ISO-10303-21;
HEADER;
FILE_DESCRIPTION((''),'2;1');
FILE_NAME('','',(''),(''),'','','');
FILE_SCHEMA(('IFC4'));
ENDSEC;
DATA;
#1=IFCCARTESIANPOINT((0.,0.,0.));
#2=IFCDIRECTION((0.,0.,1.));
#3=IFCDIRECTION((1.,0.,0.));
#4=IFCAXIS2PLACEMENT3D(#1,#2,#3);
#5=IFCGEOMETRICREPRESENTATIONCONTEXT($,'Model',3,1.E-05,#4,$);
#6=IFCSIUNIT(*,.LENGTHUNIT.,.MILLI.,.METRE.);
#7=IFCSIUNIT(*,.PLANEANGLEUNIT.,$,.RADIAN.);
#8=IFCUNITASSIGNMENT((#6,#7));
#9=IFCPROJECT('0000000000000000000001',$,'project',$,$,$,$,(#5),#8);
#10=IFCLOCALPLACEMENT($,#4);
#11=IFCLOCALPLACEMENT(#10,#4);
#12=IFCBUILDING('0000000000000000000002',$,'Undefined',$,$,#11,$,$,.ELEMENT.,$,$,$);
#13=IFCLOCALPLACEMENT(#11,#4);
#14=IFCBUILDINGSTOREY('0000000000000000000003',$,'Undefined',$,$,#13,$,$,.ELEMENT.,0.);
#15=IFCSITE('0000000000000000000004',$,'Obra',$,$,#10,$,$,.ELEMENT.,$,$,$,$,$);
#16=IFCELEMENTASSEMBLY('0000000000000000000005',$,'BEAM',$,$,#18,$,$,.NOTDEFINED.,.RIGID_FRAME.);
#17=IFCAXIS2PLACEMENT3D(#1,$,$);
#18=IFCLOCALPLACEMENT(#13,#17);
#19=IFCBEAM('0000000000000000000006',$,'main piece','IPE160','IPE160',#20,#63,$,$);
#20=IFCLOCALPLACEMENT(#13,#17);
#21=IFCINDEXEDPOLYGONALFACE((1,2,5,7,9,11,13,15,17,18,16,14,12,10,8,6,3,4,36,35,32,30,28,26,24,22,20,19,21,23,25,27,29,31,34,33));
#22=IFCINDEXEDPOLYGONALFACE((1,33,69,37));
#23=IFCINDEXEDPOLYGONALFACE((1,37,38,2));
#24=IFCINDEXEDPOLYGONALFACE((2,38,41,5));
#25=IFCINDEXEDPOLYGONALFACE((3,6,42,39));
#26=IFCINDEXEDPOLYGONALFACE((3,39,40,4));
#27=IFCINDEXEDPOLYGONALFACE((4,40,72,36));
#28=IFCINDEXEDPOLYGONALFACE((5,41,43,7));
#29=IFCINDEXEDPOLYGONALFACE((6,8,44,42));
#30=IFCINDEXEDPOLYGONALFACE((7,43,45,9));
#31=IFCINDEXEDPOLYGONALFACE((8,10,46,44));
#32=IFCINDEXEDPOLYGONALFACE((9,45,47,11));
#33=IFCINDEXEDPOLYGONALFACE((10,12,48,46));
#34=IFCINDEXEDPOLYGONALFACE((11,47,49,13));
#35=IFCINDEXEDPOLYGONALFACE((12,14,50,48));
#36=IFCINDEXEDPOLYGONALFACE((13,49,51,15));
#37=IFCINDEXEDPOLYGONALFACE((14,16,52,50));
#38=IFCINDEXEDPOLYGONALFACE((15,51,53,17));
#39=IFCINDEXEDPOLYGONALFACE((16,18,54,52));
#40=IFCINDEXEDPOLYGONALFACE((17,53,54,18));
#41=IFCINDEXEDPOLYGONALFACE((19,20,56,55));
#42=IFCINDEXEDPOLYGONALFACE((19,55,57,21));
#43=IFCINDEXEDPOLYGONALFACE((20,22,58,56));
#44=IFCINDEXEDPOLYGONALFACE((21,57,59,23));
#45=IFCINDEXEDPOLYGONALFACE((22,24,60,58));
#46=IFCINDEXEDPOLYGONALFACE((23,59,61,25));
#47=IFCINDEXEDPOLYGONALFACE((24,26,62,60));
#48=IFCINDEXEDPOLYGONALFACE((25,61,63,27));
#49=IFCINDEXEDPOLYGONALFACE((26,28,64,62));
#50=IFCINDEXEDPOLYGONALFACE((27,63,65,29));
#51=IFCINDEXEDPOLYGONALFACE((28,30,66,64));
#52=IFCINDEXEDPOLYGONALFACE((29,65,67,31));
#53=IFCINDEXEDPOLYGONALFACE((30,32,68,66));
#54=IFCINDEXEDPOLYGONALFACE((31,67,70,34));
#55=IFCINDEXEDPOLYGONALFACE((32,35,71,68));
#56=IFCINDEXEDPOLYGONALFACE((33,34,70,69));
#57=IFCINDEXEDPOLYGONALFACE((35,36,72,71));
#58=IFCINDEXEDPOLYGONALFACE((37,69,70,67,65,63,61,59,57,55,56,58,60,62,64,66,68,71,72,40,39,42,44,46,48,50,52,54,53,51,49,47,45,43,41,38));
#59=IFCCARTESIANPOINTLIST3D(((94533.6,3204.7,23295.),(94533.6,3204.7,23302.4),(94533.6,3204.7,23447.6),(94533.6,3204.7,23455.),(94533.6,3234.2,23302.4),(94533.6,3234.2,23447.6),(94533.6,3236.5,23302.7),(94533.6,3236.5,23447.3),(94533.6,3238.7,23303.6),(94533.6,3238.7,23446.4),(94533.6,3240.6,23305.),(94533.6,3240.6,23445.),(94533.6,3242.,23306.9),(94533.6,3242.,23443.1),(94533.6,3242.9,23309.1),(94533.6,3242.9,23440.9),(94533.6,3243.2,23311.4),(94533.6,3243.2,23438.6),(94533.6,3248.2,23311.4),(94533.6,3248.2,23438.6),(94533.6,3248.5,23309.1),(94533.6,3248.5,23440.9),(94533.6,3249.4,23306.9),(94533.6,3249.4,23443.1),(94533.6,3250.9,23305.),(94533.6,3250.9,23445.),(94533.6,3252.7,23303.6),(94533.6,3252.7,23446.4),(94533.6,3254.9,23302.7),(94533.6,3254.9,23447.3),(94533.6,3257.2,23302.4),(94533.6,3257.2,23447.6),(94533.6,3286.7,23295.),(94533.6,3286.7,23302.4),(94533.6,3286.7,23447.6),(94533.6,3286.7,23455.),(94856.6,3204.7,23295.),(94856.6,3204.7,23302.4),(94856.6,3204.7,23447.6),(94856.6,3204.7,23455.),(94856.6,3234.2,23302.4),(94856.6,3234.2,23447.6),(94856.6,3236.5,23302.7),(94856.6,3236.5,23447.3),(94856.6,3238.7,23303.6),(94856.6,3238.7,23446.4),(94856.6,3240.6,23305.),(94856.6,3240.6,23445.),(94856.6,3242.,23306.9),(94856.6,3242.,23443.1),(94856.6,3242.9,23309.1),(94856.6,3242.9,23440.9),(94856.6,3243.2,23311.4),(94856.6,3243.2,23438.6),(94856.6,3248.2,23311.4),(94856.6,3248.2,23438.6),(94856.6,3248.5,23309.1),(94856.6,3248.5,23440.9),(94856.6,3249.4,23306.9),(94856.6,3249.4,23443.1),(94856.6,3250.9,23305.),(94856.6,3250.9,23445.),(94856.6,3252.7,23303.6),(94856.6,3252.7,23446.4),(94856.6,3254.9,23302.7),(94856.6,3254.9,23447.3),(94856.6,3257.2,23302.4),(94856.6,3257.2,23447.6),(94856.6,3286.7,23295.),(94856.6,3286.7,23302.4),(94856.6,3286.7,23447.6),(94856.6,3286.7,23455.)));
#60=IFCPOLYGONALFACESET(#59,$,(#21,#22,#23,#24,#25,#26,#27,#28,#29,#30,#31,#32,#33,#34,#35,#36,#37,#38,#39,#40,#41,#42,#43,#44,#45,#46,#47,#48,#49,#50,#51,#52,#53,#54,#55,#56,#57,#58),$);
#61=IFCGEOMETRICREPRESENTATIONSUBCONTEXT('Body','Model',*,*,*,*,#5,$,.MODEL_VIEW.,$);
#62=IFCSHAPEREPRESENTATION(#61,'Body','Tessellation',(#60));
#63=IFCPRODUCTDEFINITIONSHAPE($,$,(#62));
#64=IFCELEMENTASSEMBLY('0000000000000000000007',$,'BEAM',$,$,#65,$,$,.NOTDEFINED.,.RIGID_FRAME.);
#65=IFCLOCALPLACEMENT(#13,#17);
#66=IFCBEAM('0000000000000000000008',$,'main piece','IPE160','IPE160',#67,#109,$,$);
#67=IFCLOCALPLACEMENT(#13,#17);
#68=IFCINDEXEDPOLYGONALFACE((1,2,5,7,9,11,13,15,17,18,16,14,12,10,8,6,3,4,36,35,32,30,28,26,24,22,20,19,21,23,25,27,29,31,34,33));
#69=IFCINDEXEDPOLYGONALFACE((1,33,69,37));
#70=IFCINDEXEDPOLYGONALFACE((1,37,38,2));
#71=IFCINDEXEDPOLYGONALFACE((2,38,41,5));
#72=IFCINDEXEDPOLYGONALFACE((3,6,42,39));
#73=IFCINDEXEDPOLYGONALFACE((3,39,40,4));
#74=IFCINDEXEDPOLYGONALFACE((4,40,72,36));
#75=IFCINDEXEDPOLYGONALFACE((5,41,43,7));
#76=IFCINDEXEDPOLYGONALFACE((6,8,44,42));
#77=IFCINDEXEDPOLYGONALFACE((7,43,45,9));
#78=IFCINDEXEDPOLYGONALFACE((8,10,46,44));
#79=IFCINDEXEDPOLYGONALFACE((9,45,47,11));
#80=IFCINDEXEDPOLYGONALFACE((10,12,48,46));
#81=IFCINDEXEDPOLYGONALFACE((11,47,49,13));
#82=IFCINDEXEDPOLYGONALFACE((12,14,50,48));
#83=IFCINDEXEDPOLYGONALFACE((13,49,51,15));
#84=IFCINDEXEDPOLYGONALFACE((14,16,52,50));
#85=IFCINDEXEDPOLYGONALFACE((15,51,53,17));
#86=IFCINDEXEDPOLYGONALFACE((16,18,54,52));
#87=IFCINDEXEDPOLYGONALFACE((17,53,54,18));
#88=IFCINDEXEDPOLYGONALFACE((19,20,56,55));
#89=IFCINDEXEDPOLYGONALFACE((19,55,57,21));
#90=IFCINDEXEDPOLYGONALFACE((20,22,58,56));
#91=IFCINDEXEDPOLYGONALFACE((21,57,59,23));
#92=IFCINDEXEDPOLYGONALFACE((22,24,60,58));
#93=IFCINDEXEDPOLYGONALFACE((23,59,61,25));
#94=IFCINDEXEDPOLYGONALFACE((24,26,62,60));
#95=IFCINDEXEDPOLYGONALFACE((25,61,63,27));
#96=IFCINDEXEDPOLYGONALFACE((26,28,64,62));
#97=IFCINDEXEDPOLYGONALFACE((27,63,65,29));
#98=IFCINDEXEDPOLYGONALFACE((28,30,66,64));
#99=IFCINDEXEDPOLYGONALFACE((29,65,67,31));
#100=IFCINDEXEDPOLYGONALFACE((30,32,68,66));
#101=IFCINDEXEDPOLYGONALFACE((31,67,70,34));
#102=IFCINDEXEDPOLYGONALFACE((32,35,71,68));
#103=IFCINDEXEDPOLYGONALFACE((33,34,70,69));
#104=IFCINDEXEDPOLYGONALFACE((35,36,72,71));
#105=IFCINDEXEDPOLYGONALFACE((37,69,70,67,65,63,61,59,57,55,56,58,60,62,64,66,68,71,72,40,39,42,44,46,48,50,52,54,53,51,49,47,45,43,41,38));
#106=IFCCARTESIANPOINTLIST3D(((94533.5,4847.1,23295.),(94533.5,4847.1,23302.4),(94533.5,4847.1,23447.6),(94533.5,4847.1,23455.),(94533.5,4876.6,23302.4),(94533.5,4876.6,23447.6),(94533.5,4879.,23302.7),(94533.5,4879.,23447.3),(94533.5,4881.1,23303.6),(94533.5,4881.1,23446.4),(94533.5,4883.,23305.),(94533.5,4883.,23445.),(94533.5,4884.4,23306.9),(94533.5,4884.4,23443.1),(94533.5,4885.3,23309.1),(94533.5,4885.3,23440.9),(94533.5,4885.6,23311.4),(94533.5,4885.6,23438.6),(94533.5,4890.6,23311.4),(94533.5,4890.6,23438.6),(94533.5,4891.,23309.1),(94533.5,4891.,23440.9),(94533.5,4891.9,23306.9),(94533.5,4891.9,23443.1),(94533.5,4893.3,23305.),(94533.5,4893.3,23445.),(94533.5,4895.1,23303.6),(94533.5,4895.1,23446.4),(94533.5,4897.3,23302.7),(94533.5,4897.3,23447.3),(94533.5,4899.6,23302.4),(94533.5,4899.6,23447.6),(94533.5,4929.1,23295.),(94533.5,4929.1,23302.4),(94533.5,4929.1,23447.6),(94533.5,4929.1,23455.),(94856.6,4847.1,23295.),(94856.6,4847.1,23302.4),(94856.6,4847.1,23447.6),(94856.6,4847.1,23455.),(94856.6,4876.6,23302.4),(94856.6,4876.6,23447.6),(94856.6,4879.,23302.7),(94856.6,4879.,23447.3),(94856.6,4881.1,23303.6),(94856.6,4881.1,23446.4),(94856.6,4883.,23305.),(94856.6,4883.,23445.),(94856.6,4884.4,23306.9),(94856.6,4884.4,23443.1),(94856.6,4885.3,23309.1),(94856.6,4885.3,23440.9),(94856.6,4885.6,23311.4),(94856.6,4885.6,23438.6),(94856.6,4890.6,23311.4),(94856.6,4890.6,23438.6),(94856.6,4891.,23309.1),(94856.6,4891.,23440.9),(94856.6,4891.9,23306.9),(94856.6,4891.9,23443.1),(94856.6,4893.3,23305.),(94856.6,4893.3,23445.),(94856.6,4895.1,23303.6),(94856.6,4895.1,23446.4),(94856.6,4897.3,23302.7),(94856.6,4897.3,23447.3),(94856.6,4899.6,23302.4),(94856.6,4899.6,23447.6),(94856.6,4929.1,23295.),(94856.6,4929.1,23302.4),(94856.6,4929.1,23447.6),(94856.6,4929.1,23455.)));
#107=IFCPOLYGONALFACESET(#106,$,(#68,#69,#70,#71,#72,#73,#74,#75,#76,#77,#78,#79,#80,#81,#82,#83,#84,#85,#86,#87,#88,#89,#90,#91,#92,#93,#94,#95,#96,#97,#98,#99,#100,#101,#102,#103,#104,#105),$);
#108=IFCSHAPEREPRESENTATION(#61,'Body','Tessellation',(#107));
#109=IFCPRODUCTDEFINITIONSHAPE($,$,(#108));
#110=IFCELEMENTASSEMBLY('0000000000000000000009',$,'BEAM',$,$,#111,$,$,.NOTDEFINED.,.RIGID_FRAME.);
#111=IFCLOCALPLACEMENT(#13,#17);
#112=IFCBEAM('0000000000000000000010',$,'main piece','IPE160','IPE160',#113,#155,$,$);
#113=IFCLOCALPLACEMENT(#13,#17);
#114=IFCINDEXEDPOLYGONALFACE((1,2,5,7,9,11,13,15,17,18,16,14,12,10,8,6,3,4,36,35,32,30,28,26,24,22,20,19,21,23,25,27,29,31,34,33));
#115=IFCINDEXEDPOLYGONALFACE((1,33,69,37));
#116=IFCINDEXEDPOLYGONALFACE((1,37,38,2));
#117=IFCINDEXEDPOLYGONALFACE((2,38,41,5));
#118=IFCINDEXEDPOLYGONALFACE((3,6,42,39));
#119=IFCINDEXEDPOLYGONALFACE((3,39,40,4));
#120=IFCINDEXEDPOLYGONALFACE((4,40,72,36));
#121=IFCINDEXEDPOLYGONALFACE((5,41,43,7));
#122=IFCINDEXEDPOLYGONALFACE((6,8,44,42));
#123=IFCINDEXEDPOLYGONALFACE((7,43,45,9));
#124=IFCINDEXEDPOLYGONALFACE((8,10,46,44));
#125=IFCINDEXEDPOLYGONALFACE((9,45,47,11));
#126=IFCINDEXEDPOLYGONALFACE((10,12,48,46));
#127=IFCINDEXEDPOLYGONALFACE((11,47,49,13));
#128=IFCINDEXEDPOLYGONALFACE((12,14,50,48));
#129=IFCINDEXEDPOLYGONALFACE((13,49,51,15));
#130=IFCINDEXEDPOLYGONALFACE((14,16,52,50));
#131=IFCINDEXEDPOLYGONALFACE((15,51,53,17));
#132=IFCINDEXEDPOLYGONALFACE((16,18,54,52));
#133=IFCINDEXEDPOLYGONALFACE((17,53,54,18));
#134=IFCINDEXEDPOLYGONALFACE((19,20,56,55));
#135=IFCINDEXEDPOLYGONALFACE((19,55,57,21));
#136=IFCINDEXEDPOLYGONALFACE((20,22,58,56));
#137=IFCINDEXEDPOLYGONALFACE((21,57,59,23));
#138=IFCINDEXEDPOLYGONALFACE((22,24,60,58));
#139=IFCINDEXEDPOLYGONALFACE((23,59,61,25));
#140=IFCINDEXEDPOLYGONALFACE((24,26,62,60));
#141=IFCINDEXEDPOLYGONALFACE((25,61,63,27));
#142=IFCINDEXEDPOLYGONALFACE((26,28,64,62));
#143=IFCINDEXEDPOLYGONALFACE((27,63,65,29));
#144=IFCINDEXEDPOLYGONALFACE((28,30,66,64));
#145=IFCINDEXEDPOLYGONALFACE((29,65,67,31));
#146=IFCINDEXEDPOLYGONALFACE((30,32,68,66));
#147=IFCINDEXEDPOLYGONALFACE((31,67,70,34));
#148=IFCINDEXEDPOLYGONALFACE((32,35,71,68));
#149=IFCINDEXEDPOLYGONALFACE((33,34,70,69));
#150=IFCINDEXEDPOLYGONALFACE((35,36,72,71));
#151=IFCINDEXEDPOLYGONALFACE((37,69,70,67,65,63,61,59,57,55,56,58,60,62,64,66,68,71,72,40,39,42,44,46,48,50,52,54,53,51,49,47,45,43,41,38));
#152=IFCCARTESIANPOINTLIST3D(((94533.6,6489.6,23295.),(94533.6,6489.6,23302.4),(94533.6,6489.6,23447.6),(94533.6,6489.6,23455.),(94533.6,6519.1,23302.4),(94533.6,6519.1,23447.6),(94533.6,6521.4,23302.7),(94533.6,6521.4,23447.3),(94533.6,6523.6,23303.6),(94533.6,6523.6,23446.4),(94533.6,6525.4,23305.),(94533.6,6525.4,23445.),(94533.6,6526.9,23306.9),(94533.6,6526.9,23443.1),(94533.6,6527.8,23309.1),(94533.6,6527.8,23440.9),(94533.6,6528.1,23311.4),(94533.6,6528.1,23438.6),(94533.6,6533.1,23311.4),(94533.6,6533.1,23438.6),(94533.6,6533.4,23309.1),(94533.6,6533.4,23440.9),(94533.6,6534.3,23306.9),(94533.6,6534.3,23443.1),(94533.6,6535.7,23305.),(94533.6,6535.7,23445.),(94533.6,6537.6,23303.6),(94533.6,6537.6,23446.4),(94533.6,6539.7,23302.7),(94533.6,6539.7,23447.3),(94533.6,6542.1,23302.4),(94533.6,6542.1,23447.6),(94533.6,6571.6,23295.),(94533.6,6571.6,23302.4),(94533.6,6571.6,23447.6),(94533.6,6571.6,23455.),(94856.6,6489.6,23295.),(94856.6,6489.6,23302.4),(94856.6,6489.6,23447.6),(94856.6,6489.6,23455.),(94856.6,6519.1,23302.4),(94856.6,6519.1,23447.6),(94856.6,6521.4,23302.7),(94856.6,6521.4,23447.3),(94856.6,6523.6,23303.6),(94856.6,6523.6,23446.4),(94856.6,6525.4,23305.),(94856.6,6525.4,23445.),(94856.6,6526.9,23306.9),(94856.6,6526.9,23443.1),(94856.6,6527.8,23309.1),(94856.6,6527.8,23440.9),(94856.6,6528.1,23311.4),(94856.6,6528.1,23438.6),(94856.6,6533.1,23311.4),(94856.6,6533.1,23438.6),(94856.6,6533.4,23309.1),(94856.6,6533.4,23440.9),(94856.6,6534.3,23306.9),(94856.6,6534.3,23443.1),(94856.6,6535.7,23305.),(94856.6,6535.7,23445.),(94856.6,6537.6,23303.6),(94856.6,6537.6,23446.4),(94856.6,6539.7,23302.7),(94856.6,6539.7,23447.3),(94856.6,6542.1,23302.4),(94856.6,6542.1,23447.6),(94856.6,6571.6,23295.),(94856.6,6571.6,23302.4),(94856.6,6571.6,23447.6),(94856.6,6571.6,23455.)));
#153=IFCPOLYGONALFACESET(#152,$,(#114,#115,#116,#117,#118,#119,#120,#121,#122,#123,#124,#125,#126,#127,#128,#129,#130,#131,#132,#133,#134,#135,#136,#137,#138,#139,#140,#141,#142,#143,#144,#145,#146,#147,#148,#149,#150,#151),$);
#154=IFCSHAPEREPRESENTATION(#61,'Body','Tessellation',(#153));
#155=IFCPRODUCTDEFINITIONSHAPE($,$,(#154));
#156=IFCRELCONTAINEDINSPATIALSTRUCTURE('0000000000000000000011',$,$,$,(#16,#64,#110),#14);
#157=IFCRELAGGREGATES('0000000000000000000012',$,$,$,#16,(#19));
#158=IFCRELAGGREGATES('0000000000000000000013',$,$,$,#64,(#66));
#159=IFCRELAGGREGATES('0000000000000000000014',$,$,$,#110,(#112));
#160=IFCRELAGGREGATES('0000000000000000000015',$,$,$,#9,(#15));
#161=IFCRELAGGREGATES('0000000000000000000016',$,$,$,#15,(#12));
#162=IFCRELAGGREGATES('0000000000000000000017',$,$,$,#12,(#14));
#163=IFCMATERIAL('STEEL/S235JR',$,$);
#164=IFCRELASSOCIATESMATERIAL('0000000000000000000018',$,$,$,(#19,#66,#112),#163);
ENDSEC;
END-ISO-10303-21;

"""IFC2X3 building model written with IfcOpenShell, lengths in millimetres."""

from ifc_helpers import new_model, si_unit, frame, origin_with_axes, origin_2d_with_axis, place, context, subcontext, project, spatial, i_section, extrude, material, element, aggregate, save


model = new_model("IFC2X3")

# Units and contexts
model_context = context("Model", 3, precision=1e-05, world=origin_with_axes())
body_context = subcontext(model_context, "Body", "Model", "MODEL_VIEW")
ifc_project = project(units=[si_unit("LENGTHUNIT", "METRE", prefix="MILLI"), si_unit("PLANEANGLEUNIT", "RADIAN")], contexts=[model_context])

# Site, building, storey
site_placement = place(None, origin_with_axes())
site = spatial("IfcSite", under=ifc_project, at=site_placement, Name="Obra", CompositionType="ELEMENT")
building_placement = place(site_placement, origin_with_axes())
building = spatial("IfcBuilding", under=site, at=building_placement, Name="Undefined", CompositionType="ELEMENT")
storey_placement = place(building_placement, origin_with_axes())
storey = spatial("IfcBuildingStorey", under=building, at=storey_placement, Name="Undefined", CompositionType="ELEMENT", Elevation=0.0)

# Shared definitions
ifc_material_1 = material(Name="STEEL/S235JR")

# Element assemblies, beams
assembly_1_placement = place(storey_placement, origin_with_axes())
assembly_1 = element("IfcElementAssembly", 1, at=assembly_1_placement, inside=storey, Name="BEAM", AssemblyPlace="NOTDEFINED", PredefinedType="RIGID_FRAME")
beam_1_placement = place(assembly_1_placement, frame((94533.6, 3245.7, 23375.0), z_axis=(0.0, 0.0, 1.0), x_axis=(1.0, 0.0, 0.0)))
beam_1 = element("IfcBeam", 2, at=beam_1_placement, material=ifc_material_1, Name="main piece", Description="IPE160", ObjectType="IPE160", context=body_context, shape_type="SweptSolid", body=[
    extrude(i_section(OverallWidth=82.0, OverallDepth=160.0, WebThickness=5.0, FlangeThickness=7.4, FilletRadius=9.0, at=origin_2d_with_axis()), frame((323.1, 0.0, 0.0), z_axis=(-1.0, 0.0, 0.0), x_axis=(0.0, -1.0, 0.0)), (0.0, 0.0, 1.0), 323.1),
])
aggregate(assembly_1, [beam_1])
assembly_2_placement = place(storey_placement, origin_with_axes())
assembly_2 = element("IfcElementAssembly", 3, at=assembly_2_placement, inside=storey, Name="BEAM", AssemblyPlace="NOTDEFINED", PredefinedType="RIGID_FRAME")
beam_2_placement = place(assembly_2_placement, frame((94533.5, 4888.1, 23375.0), z_axis=(0.0, 0.0, 1.0), x_axis=(1.0, 0.0, 0.0)))
beam_2 = element("IfcBeam", 4, at=beam_2_placement, material=ifc_material_1, Name="main piece", Description="IPE160", ObjectType="IPE160", context=body_context, shape_type="SweptSolid", body=[
    extrude(i_section(OverallWidth=82.0, OverallDepth=160.0, WebThickness=5.0, FlangeThickness=7.4, FilletRadius=9.0, at=origin_2d_with_axis()), frame((323.1, 0.0, 0.0), z_axis=(-1.0, 0.0, 0.0), x_axis=(0.0, -1.0, 0.0)), (0.0, 0.0, 1.0), 323.1),
])
aggregate(assembly_2, [beam_2])
assembly_3_placement = place(storey_placement, origin_with_axes())
assembly_3 = element("IfcElementAssembly", 5, at=assembly_3_placement, inside=storey, Name="BEAM", AssemblyPlace="NOTDEFINED", PredefinedType="RIGID_FRAME")
beam_3_placement = place(assembly_3_placement, frame((94533.6, 6530.6, 23375.0), z_axis=(0.0, 0.0, 1.0), x_axis=(1.0, 0.0, 0.0)))
beam_3 = element("IfcBeam", 6, at=beam_3_placement, material=ifc_material_1, Name="main piece", Description="IPE160", ObjectType="IPE160", context=body_context, shape_type="SweptSolid", body=[
    extrude(i_section(OverallWidth=82.0, OverallDepth=160.0, WebThickness=5.0, FlangeThickness=7.4, FilletRadius=9.0, at=origin_2d_with_axis()), frame((323.1, 0.0, 0.0), z_axis=(-1.0, 0.0, 0.0), x_axis=(0.0, -1.0, 0.0)), (0.0, 0.0, 1.0), 323.1),
])
aggregate(assembly_3, [beam_3])

save(model, "model.ifc")
